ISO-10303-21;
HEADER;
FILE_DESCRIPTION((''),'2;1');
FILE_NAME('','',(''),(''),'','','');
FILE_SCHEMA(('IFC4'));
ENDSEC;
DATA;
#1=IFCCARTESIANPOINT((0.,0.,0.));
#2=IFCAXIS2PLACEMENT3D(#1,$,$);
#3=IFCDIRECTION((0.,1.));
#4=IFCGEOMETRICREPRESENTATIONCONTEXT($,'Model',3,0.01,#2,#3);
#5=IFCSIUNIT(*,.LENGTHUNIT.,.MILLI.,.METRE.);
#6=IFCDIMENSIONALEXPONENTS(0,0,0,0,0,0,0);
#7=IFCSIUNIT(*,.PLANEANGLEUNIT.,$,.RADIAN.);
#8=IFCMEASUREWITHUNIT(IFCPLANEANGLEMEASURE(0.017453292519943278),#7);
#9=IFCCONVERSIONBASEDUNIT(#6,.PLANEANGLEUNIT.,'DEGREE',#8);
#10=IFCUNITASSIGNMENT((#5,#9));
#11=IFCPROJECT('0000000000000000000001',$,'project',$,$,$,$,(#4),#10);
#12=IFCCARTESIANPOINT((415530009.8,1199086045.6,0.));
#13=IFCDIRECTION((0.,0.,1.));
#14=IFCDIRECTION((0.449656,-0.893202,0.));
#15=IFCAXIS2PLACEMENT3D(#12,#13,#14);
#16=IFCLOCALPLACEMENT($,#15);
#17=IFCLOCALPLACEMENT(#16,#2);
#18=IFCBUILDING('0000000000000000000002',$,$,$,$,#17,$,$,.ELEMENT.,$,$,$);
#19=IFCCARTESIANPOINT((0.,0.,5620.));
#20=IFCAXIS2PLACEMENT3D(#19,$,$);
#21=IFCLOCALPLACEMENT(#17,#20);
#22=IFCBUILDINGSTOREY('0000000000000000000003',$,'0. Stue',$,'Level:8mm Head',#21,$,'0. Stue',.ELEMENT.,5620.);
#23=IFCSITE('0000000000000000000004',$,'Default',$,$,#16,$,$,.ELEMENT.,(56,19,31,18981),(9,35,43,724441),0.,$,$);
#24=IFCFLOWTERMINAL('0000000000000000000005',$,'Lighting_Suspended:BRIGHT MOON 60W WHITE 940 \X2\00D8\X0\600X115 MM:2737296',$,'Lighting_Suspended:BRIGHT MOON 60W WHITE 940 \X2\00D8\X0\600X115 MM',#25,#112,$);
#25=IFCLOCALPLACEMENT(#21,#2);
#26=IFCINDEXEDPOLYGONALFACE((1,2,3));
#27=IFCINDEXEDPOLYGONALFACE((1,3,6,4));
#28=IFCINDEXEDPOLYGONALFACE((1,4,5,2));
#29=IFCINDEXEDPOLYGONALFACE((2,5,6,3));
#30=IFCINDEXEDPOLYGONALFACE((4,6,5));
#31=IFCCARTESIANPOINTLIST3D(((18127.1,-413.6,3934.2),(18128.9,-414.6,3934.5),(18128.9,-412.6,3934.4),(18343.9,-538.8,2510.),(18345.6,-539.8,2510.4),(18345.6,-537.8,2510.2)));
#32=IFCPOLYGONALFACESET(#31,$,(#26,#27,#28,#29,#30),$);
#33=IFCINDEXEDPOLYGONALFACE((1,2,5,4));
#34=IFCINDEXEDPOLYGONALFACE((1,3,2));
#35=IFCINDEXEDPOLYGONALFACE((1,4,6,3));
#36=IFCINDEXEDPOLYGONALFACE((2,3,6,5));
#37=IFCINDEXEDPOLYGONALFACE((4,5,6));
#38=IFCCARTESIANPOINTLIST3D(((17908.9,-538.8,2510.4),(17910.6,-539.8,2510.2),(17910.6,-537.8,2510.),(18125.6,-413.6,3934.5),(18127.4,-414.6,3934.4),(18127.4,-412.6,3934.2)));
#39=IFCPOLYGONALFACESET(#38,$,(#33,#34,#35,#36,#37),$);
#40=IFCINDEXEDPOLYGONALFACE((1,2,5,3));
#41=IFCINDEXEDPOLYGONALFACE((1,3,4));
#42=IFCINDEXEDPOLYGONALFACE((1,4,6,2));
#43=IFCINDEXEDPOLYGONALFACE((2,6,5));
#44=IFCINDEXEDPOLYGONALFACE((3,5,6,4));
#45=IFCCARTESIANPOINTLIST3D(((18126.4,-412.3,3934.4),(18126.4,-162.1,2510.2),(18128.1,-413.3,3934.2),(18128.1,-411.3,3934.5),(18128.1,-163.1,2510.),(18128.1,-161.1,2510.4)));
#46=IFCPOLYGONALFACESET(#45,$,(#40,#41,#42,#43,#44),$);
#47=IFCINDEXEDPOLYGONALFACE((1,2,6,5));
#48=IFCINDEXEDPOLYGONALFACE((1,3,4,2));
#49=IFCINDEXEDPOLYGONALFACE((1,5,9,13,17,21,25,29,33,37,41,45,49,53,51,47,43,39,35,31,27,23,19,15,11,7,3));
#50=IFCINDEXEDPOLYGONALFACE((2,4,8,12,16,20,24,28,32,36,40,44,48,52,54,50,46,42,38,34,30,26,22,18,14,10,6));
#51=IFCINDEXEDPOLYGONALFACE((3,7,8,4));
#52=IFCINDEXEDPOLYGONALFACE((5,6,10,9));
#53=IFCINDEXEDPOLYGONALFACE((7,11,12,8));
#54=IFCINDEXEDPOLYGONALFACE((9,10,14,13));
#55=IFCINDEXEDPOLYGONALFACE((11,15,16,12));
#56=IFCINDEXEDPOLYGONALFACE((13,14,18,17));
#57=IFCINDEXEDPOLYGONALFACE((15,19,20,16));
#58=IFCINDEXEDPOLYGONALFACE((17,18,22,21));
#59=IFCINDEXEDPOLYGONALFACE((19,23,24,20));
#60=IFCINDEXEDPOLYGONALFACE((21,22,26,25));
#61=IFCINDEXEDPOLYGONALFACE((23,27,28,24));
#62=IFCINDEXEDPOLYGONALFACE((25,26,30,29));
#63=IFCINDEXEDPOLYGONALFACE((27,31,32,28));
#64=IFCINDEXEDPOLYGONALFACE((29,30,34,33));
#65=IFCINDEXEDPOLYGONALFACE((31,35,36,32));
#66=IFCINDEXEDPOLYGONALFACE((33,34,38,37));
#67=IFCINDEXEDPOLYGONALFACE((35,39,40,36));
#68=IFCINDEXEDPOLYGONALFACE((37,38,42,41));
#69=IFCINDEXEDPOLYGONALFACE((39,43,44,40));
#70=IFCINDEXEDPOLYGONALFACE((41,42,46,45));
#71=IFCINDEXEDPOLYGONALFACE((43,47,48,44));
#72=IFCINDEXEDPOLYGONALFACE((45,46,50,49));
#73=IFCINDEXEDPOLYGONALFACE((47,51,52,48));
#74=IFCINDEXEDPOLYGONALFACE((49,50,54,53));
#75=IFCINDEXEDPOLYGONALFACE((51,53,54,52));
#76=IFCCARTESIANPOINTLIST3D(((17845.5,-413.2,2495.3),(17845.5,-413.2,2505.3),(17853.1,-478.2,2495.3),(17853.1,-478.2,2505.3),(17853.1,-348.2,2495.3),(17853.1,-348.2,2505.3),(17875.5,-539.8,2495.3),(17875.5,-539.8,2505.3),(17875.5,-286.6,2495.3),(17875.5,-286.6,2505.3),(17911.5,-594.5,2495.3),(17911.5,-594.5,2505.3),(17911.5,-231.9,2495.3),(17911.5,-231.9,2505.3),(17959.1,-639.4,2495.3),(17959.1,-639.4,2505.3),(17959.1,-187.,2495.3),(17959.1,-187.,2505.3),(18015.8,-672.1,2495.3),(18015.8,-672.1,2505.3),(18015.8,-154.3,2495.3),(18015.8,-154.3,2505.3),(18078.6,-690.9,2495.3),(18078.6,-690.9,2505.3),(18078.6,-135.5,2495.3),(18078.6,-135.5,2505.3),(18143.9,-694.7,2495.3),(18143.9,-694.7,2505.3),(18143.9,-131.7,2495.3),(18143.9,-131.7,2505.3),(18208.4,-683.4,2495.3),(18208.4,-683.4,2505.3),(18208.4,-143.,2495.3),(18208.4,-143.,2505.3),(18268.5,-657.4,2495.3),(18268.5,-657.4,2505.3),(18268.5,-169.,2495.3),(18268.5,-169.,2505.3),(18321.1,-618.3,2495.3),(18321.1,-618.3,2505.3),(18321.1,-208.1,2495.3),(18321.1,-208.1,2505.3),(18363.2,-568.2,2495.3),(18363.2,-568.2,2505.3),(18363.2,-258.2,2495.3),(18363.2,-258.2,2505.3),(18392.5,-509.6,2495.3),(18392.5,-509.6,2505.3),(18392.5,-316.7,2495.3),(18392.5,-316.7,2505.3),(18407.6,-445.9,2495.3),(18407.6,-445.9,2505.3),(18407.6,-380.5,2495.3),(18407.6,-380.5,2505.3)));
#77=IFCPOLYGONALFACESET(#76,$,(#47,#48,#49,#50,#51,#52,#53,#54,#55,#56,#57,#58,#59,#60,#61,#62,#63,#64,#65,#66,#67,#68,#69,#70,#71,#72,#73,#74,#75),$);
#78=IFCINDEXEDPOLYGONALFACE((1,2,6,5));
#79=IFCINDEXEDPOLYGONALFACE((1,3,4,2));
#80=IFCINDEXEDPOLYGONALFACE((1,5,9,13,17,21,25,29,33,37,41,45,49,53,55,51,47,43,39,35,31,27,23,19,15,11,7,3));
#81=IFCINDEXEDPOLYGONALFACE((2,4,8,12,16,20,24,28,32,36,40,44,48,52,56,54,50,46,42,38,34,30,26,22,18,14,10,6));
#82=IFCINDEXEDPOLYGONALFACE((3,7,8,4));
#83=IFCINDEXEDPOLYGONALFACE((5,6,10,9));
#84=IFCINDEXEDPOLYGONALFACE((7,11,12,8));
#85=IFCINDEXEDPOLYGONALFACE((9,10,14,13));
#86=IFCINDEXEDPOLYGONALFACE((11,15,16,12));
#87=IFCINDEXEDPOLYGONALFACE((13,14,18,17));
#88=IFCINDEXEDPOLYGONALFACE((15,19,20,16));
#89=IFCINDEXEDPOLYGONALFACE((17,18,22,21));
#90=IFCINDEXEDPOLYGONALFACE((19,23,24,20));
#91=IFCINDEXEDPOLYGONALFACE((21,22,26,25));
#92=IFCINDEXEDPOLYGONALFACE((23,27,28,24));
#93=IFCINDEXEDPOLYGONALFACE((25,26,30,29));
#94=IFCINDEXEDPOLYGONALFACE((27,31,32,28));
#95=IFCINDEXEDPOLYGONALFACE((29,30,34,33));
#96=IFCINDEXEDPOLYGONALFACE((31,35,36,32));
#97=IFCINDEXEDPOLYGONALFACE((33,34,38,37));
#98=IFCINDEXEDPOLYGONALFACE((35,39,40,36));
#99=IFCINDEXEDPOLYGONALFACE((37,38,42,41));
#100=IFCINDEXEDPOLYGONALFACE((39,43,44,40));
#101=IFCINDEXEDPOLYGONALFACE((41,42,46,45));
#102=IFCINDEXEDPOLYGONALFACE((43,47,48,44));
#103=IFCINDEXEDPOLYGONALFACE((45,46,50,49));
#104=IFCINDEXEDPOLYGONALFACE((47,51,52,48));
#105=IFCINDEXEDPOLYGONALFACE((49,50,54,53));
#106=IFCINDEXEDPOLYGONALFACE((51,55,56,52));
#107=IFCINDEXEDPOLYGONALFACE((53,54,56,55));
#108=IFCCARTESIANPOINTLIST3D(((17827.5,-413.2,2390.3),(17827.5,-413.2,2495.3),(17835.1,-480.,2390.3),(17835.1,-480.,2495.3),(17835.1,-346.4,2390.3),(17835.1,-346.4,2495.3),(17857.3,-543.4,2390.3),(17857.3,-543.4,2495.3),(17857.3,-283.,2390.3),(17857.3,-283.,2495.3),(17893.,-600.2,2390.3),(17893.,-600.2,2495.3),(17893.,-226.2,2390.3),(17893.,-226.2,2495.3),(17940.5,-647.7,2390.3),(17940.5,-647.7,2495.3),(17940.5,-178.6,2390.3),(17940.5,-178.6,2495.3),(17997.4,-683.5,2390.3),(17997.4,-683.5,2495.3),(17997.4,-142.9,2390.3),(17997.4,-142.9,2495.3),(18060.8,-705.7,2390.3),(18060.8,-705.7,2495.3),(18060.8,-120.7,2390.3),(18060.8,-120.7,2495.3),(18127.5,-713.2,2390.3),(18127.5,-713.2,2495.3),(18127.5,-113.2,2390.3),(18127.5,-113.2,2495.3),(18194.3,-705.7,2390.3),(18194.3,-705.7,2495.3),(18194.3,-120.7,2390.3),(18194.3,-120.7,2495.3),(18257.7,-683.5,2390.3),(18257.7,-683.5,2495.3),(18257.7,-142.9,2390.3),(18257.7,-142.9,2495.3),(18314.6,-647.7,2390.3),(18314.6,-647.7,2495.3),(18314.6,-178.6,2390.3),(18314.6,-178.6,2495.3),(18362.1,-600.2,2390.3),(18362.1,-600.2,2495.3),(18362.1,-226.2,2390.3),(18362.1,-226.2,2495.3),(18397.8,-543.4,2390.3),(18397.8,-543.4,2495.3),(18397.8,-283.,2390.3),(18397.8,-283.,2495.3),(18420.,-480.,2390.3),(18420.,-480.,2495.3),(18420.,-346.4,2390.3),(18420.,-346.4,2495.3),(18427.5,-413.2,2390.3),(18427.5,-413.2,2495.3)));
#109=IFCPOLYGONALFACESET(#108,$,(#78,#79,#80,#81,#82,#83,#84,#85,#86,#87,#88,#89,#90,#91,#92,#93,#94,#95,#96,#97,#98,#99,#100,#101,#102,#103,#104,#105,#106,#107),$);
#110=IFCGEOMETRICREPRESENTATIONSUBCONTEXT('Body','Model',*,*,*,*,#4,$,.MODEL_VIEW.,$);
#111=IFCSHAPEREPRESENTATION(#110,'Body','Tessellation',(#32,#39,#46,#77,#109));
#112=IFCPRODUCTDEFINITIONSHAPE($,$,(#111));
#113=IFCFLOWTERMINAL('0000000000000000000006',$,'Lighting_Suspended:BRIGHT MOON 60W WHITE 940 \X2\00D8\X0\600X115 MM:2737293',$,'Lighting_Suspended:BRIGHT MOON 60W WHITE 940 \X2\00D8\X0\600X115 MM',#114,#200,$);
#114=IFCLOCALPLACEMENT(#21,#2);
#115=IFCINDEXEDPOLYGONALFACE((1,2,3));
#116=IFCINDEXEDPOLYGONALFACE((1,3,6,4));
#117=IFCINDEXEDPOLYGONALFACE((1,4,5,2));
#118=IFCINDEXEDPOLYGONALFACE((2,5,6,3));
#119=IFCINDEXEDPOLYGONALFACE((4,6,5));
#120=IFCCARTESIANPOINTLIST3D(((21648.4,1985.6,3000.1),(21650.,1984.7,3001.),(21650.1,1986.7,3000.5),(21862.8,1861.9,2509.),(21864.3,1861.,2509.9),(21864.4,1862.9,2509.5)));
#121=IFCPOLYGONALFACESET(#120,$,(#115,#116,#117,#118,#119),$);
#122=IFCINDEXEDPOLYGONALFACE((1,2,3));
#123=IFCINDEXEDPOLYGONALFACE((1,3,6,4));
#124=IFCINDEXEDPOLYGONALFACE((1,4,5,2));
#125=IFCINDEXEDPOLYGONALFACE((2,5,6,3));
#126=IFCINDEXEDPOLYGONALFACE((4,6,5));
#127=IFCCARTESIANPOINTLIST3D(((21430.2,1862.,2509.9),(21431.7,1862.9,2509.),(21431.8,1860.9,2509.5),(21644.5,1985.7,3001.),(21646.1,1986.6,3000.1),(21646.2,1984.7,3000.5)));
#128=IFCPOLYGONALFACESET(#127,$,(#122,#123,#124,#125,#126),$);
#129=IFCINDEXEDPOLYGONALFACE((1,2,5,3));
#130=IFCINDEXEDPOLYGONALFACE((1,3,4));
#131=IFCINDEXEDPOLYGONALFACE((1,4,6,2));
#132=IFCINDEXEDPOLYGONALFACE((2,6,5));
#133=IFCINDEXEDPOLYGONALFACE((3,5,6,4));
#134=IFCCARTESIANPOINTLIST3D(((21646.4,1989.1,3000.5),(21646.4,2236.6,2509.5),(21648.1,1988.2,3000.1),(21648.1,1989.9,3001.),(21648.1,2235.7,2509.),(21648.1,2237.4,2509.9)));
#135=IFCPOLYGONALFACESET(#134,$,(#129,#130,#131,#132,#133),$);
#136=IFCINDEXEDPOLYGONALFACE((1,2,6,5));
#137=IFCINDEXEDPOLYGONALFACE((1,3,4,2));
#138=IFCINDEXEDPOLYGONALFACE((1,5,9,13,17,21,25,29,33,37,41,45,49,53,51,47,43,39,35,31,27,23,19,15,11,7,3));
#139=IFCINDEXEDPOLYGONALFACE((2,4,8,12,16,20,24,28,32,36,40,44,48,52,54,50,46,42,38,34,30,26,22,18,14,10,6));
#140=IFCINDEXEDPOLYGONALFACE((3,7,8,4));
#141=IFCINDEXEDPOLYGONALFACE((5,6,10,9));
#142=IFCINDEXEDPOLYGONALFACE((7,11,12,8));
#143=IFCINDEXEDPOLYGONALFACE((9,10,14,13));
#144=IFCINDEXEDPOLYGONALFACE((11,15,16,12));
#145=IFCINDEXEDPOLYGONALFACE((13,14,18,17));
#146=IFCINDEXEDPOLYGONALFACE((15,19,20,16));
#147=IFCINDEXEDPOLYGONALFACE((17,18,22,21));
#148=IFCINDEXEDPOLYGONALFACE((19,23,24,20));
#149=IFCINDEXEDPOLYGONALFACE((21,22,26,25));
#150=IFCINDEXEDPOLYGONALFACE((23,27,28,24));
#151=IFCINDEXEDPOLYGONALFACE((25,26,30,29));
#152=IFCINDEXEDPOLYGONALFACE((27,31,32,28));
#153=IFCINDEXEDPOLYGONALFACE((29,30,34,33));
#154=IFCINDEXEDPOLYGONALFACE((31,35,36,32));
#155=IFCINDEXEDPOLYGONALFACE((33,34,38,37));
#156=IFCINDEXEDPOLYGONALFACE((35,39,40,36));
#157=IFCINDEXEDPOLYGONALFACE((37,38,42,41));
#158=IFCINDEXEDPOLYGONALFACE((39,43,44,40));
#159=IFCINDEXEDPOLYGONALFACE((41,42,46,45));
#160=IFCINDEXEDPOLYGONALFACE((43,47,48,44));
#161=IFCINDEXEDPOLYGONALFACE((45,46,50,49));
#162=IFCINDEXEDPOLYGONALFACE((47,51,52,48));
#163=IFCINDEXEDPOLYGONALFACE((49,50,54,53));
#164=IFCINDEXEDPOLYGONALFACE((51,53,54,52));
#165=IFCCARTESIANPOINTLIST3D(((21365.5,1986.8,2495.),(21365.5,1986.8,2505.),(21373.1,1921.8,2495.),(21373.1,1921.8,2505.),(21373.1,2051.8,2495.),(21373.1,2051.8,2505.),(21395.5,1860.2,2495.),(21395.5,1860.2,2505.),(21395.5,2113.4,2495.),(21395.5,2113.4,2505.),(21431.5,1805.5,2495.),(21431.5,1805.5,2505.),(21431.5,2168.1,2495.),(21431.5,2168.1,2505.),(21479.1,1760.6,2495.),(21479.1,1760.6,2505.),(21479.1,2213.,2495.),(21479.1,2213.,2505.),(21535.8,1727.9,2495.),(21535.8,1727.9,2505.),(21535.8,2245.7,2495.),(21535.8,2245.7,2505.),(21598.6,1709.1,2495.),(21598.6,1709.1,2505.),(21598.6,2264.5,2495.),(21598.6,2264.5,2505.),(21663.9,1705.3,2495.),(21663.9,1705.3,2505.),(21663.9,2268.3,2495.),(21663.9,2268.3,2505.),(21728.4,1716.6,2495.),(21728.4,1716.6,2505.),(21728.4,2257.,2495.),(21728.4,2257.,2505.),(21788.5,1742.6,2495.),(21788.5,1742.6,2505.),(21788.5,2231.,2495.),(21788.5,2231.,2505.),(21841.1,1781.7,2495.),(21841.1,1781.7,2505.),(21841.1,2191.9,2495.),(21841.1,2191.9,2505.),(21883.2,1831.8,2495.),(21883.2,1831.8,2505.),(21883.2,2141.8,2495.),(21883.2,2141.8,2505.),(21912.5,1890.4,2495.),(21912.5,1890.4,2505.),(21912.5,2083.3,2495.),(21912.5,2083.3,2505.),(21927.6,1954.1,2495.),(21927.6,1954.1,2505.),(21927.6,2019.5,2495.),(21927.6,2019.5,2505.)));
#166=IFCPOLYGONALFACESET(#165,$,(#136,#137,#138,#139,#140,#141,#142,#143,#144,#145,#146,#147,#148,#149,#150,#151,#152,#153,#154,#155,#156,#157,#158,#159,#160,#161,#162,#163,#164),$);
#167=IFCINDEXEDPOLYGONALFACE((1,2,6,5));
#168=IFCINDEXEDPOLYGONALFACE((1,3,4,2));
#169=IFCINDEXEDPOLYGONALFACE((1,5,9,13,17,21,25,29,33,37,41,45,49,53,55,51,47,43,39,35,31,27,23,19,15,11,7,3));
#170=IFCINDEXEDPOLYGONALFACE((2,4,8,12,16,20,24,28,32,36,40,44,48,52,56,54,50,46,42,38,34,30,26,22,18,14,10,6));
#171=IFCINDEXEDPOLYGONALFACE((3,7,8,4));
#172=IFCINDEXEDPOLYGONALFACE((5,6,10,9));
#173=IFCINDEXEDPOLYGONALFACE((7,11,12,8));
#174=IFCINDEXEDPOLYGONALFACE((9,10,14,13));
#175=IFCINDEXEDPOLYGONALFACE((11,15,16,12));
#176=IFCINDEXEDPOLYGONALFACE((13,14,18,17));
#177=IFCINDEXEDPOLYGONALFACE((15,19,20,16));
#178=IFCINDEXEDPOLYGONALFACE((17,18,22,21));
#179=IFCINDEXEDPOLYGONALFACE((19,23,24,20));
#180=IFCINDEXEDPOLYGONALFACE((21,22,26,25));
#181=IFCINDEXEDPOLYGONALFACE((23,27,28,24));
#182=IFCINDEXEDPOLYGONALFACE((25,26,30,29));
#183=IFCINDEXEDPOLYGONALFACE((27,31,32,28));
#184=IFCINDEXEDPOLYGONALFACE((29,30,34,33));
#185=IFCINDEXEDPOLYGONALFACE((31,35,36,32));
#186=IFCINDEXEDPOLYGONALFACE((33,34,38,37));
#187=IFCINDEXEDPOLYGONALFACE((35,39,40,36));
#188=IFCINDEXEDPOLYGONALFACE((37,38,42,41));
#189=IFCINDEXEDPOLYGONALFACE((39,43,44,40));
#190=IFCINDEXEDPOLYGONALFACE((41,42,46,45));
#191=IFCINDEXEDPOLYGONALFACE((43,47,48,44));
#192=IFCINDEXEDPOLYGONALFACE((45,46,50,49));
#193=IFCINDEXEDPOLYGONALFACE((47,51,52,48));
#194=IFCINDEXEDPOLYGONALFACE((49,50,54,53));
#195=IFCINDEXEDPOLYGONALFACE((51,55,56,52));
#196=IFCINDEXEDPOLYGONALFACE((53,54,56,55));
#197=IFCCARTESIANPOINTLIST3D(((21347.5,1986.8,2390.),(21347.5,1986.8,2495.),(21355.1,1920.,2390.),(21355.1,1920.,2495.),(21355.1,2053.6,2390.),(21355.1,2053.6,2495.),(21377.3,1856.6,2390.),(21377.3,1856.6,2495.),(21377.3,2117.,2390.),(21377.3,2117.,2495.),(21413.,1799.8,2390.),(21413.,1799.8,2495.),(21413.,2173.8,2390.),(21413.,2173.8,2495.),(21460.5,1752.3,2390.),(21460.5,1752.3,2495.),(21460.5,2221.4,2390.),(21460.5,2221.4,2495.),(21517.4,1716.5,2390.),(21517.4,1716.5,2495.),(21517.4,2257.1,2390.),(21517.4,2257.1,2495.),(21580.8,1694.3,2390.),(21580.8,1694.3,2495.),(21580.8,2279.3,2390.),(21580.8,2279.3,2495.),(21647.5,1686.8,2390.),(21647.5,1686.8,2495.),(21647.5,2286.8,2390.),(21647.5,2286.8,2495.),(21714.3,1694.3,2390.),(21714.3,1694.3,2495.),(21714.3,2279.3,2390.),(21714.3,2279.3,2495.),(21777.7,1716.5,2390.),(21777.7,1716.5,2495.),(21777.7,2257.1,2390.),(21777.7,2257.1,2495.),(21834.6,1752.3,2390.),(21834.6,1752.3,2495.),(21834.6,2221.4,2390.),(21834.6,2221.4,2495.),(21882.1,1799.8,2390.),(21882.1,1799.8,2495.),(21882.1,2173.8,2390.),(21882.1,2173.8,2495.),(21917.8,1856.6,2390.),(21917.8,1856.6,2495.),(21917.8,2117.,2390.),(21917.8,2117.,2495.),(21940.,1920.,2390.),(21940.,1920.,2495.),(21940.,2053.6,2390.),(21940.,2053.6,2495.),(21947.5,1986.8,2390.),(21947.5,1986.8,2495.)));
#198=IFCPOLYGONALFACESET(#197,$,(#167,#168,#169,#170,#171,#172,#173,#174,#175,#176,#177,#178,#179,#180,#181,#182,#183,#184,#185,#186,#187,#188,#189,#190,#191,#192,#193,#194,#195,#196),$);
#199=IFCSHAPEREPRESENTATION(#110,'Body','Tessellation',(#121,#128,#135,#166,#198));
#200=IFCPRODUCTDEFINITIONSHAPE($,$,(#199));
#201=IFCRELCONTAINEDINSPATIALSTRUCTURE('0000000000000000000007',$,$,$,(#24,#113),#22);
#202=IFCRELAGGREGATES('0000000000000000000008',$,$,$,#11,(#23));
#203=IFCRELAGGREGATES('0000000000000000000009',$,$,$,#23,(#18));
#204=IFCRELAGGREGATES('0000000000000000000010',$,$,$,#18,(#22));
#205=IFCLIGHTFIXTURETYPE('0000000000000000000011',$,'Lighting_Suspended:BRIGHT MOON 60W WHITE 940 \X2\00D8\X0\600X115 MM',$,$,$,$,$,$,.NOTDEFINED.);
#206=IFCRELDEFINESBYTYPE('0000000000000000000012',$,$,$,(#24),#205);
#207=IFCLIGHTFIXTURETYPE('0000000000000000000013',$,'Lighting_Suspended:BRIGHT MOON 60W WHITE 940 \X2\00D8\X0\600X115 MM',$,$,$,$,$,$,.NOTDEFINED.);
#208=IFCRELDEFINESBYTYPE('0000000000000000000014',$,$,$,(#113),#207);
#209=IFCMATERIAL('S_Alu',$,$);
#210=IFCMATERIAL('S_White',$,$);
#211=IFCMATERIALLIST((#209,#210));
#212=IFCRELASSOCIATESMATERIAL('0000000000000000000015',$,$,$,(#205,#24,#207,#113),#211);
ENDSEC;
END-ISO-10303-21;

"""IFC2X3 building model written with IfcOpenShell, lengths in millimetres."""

from ifc_helpers import new_model, entity, si_unit, converted_unit, direction, frame, frame_2d, origin, place, context, subcontext, project, spatial, polyline, circle, outline, extrude, source, transform, mapped, material, material_list, type_object, type_shapes, element, save


model = new_model("IFC2X3")

# Units and contexts
model_context = context("Model", 3, precision=0.01, world=origin(), true_north=direction((0.0, 1.0)))
body_context = subcontext(model_context, "Body", "Model", "MODEL_VIEW")
ifc_project = project(units=[si_unit("LENGTHUNIT", "METRE", prefix="MILLI"), converted_unit("PLANEANGLEUNIT", "DEGREE", entity("IfcPlaneAngleMeasure", 0.017453292519943278), si_unit("PLANEANGLEUNIT", "RADIAN"), dimensions=[0, 0, 0, 0, 0, 0, 0])], contexts=[model_context])

# Site, building, storey
site_placement = place(None, frame((415530009.8, 1199086045.6, 0.0), z_axis=(0.0, 0.0, 1.0), x_axis=(0.449656, -0.893202, 0.0)))
site = spatial("IfcSite", under=ifc_project, at=site_placement, Name="Default", CompositionType="ELEMENT", RefLatitude=(56, 19, 31, 18981), RefLongitude=(9, 35, 43, 724441), RefElevation=0.0)
building_placement = place(site_placement, origin())
building = spatial("IfcBuilding", under=site, at=building_placement, CompositionType="ELEMENT")
storey_placement = place(building_placement, frame((0.0, 0.0, 5620.0)))
storey = spatial("IfcBuildingStorey", under=building, at=storey_placement, Name="0. Stue", ObjectType="Level:8mm Head", LongName="0. Stue", CompositionType="ELEMENT", Elevation=5620.0)

# Flow terminals
ifc_material_1 = material(Name="S_White")
ifc_material_2 = material(Name="S_Alu")
ifc_material_list = material_list([ifc_material_2, ifc_material_1])
light_fixture_type_1 = type_object("IfcLightFixtureType", Name="Lighting_Suspended:BRIGHT MOON 60W WHITE 940 Ø600X115 MM", PredefinedType="NOTDEFINED", material=ifc_material_list)
shared_shape_1 = source(origin(), body_context, "Body", "SweptSolid", [
    extrude(outline(polyline([(-1.0, -0.6), (1.0, -0.6), (0.0, 1.2), (-1.0, -0.6)])), frame((-217.5, 125.6, -1429.1), z_axis=(0.149892, -0.08654, 0.984908), x_axis=(-0.852955, 0.492454, 0.17308)), (0.0, 0.0, 1.0), 1446.0),
    extrude(outline(polyline([(-1.0, -0.6), (1.0, -0.6), (0.0, 1.2), (-1.0, -0.6)])), frame((217.5, 125.6, -1429.1), z_axis=(-0.149892, -0.08654, 0.984908), x_axis=(0.852955, 0.492454, 0.17308)), (0.0, 0.0, 1.0), 1446.0),
    extrude(outline(polyline([(-1.0, -0.6), (1.0, -0.6), (0.0, 1.2), (-1.0, -0.6)])), frame((0.0, -251.1, -1429.1), z_axis=(0.0, 0.17308, 0.984908), x_axis=(0.0, -0.984908, 0.17308)), (0.0, 0.0, 1.0), 1446.0),
    extrude(circle(Radius=282.0, at=frame_2d((0.0, 0.0), x_axis=(1.0, 0.0))), frame((0.0, 0.0, -1444.0)), (0.0, 0.0, 1.0), 10.0),
    extrude(circle(Radius=300.0, at=frame_2d((0.0, 0.0), x_axis=(1.0, 0.0))), frame((0.0, 0.0, -1549.0)), (0.0, 0.0, 1.0), 105.0),
])
type_shapes(light_fixture_type_1, [shared_shape_1])
for number, where, z_axis, x_axis, name in (
    (1, (18127.5, -413.2, 3939.3), (0.0, 0.0, 1.0), (-1.0, 0.0, 0.0), "Lighting_Suspended:BRIGHT MOON 60W WHITE 940 Ø600X115 MM:2737296"),
):
    element("IfcFlowTerminal", number, at=place(storey_placement, frame(where, z_axis=z_axis, x_axis=x_axis)), inside=storey, type_object=light_fixture_type_1, material=ifc_material_list, Name=name, ObjectType="Lighting_Suspended:BRIGHT MOON 60W WHITE 940 Ø600X115 MM", context=body_context, shape_type="MappedRepresentation", body=[
        mapped(shared_shape_1, transform((0.0, 0.0, 0.0), scale=1.0)),
    ])
light_fixture_type_2 = type_object("IfcLightFixtureType", Name="Lighting_Suspended:BRIGHT MOON 60W WHITE 940 Ø600X115 MM", PredefinedType="NOTDEFINED", material=ifc_material_list)
shared_shape_2 = source(origin(), body_context, "Body", "SweptSolid", [
    extrude(outline(polyline([(-1.0, -0.6), (1.0, -0.6), (0.0, 1.2), (-1.0, -0.6)])), frame((-216.3, 124.9, -495.5), z_axis=(0.389771, -0.225034, 0.892994), x_axis=(-0.773355, 0.446497, 0.450069)), (0.0, 0.0, 1.0), 549.9),
    extrude(outline(polyline([(-1.0, -0.6), (1.0, -0.6), (0.0, 1.2), (-1.0, -0.6)])), frame((216.3, 124.9, -495.5), z_axis=(-0.389771, -0.225034, 0.892994), x_axis=(0.773355, 0.446497, 0.450069)), (0.0, 0.0, 1.0), 549.9),
    extrude(outline(polyline([(-1.0, -0.6), (1.0, -0.6), (0.0, 1.2), (-1.0, -0.6)])), frame((0.0, -249.7, -495.5), z_axis=(0.0, 0.450069, 0.892994), x_axis=(0.0, -0.892994, 0.450069)), (0.0, 0.0, 1.0), 549.9),
    extrude(circle(Radius=282.0, at=frame_2d((0.0, 0.0), x_axis=(1.0, 0.0))), frame((0.0, 0.0, -510.0)), (0.0, 0.0, 1.0), 10.0),
    extrude(circle(Radius=300.0, at=frame_2d((0.0, 0.0), x_axis=(1.0, 0.0))), frame((0.0, 0.0, -615.0)), (0.0, 0.0, 1.0), 105.0),
])
type_shapes(light_fixture_type_2, [shared_shape_2])
flow_terminal_placement = place(storey_placement, frame((21647.5, 1986.8, 3005.0), z_axis=(0.0, 0.0, 1.0), x_axis=(-1.0, 0.0, 0.0)))
element("IfcFlowTerminal", 2, at=flow_terminal_placement, inside=storey, type_object=light_fixture_type_2, material=ifc_material_list, Name="Lighting_Suspended:BRIGHT MOON 60W WHITE 940 Ø600X115 MM:2737293", ObjectType="Lighting_Suspended:BRIGHT MOON 60W WHITE 940 Ø600X115 MM", context=body_context, shape_type="MappedRepresentation", body=[
    mapped(shared_shape_2, transform((0.0, 0.0, 0.0), scale=1.0)),
])

save(model, "model.ifc")
